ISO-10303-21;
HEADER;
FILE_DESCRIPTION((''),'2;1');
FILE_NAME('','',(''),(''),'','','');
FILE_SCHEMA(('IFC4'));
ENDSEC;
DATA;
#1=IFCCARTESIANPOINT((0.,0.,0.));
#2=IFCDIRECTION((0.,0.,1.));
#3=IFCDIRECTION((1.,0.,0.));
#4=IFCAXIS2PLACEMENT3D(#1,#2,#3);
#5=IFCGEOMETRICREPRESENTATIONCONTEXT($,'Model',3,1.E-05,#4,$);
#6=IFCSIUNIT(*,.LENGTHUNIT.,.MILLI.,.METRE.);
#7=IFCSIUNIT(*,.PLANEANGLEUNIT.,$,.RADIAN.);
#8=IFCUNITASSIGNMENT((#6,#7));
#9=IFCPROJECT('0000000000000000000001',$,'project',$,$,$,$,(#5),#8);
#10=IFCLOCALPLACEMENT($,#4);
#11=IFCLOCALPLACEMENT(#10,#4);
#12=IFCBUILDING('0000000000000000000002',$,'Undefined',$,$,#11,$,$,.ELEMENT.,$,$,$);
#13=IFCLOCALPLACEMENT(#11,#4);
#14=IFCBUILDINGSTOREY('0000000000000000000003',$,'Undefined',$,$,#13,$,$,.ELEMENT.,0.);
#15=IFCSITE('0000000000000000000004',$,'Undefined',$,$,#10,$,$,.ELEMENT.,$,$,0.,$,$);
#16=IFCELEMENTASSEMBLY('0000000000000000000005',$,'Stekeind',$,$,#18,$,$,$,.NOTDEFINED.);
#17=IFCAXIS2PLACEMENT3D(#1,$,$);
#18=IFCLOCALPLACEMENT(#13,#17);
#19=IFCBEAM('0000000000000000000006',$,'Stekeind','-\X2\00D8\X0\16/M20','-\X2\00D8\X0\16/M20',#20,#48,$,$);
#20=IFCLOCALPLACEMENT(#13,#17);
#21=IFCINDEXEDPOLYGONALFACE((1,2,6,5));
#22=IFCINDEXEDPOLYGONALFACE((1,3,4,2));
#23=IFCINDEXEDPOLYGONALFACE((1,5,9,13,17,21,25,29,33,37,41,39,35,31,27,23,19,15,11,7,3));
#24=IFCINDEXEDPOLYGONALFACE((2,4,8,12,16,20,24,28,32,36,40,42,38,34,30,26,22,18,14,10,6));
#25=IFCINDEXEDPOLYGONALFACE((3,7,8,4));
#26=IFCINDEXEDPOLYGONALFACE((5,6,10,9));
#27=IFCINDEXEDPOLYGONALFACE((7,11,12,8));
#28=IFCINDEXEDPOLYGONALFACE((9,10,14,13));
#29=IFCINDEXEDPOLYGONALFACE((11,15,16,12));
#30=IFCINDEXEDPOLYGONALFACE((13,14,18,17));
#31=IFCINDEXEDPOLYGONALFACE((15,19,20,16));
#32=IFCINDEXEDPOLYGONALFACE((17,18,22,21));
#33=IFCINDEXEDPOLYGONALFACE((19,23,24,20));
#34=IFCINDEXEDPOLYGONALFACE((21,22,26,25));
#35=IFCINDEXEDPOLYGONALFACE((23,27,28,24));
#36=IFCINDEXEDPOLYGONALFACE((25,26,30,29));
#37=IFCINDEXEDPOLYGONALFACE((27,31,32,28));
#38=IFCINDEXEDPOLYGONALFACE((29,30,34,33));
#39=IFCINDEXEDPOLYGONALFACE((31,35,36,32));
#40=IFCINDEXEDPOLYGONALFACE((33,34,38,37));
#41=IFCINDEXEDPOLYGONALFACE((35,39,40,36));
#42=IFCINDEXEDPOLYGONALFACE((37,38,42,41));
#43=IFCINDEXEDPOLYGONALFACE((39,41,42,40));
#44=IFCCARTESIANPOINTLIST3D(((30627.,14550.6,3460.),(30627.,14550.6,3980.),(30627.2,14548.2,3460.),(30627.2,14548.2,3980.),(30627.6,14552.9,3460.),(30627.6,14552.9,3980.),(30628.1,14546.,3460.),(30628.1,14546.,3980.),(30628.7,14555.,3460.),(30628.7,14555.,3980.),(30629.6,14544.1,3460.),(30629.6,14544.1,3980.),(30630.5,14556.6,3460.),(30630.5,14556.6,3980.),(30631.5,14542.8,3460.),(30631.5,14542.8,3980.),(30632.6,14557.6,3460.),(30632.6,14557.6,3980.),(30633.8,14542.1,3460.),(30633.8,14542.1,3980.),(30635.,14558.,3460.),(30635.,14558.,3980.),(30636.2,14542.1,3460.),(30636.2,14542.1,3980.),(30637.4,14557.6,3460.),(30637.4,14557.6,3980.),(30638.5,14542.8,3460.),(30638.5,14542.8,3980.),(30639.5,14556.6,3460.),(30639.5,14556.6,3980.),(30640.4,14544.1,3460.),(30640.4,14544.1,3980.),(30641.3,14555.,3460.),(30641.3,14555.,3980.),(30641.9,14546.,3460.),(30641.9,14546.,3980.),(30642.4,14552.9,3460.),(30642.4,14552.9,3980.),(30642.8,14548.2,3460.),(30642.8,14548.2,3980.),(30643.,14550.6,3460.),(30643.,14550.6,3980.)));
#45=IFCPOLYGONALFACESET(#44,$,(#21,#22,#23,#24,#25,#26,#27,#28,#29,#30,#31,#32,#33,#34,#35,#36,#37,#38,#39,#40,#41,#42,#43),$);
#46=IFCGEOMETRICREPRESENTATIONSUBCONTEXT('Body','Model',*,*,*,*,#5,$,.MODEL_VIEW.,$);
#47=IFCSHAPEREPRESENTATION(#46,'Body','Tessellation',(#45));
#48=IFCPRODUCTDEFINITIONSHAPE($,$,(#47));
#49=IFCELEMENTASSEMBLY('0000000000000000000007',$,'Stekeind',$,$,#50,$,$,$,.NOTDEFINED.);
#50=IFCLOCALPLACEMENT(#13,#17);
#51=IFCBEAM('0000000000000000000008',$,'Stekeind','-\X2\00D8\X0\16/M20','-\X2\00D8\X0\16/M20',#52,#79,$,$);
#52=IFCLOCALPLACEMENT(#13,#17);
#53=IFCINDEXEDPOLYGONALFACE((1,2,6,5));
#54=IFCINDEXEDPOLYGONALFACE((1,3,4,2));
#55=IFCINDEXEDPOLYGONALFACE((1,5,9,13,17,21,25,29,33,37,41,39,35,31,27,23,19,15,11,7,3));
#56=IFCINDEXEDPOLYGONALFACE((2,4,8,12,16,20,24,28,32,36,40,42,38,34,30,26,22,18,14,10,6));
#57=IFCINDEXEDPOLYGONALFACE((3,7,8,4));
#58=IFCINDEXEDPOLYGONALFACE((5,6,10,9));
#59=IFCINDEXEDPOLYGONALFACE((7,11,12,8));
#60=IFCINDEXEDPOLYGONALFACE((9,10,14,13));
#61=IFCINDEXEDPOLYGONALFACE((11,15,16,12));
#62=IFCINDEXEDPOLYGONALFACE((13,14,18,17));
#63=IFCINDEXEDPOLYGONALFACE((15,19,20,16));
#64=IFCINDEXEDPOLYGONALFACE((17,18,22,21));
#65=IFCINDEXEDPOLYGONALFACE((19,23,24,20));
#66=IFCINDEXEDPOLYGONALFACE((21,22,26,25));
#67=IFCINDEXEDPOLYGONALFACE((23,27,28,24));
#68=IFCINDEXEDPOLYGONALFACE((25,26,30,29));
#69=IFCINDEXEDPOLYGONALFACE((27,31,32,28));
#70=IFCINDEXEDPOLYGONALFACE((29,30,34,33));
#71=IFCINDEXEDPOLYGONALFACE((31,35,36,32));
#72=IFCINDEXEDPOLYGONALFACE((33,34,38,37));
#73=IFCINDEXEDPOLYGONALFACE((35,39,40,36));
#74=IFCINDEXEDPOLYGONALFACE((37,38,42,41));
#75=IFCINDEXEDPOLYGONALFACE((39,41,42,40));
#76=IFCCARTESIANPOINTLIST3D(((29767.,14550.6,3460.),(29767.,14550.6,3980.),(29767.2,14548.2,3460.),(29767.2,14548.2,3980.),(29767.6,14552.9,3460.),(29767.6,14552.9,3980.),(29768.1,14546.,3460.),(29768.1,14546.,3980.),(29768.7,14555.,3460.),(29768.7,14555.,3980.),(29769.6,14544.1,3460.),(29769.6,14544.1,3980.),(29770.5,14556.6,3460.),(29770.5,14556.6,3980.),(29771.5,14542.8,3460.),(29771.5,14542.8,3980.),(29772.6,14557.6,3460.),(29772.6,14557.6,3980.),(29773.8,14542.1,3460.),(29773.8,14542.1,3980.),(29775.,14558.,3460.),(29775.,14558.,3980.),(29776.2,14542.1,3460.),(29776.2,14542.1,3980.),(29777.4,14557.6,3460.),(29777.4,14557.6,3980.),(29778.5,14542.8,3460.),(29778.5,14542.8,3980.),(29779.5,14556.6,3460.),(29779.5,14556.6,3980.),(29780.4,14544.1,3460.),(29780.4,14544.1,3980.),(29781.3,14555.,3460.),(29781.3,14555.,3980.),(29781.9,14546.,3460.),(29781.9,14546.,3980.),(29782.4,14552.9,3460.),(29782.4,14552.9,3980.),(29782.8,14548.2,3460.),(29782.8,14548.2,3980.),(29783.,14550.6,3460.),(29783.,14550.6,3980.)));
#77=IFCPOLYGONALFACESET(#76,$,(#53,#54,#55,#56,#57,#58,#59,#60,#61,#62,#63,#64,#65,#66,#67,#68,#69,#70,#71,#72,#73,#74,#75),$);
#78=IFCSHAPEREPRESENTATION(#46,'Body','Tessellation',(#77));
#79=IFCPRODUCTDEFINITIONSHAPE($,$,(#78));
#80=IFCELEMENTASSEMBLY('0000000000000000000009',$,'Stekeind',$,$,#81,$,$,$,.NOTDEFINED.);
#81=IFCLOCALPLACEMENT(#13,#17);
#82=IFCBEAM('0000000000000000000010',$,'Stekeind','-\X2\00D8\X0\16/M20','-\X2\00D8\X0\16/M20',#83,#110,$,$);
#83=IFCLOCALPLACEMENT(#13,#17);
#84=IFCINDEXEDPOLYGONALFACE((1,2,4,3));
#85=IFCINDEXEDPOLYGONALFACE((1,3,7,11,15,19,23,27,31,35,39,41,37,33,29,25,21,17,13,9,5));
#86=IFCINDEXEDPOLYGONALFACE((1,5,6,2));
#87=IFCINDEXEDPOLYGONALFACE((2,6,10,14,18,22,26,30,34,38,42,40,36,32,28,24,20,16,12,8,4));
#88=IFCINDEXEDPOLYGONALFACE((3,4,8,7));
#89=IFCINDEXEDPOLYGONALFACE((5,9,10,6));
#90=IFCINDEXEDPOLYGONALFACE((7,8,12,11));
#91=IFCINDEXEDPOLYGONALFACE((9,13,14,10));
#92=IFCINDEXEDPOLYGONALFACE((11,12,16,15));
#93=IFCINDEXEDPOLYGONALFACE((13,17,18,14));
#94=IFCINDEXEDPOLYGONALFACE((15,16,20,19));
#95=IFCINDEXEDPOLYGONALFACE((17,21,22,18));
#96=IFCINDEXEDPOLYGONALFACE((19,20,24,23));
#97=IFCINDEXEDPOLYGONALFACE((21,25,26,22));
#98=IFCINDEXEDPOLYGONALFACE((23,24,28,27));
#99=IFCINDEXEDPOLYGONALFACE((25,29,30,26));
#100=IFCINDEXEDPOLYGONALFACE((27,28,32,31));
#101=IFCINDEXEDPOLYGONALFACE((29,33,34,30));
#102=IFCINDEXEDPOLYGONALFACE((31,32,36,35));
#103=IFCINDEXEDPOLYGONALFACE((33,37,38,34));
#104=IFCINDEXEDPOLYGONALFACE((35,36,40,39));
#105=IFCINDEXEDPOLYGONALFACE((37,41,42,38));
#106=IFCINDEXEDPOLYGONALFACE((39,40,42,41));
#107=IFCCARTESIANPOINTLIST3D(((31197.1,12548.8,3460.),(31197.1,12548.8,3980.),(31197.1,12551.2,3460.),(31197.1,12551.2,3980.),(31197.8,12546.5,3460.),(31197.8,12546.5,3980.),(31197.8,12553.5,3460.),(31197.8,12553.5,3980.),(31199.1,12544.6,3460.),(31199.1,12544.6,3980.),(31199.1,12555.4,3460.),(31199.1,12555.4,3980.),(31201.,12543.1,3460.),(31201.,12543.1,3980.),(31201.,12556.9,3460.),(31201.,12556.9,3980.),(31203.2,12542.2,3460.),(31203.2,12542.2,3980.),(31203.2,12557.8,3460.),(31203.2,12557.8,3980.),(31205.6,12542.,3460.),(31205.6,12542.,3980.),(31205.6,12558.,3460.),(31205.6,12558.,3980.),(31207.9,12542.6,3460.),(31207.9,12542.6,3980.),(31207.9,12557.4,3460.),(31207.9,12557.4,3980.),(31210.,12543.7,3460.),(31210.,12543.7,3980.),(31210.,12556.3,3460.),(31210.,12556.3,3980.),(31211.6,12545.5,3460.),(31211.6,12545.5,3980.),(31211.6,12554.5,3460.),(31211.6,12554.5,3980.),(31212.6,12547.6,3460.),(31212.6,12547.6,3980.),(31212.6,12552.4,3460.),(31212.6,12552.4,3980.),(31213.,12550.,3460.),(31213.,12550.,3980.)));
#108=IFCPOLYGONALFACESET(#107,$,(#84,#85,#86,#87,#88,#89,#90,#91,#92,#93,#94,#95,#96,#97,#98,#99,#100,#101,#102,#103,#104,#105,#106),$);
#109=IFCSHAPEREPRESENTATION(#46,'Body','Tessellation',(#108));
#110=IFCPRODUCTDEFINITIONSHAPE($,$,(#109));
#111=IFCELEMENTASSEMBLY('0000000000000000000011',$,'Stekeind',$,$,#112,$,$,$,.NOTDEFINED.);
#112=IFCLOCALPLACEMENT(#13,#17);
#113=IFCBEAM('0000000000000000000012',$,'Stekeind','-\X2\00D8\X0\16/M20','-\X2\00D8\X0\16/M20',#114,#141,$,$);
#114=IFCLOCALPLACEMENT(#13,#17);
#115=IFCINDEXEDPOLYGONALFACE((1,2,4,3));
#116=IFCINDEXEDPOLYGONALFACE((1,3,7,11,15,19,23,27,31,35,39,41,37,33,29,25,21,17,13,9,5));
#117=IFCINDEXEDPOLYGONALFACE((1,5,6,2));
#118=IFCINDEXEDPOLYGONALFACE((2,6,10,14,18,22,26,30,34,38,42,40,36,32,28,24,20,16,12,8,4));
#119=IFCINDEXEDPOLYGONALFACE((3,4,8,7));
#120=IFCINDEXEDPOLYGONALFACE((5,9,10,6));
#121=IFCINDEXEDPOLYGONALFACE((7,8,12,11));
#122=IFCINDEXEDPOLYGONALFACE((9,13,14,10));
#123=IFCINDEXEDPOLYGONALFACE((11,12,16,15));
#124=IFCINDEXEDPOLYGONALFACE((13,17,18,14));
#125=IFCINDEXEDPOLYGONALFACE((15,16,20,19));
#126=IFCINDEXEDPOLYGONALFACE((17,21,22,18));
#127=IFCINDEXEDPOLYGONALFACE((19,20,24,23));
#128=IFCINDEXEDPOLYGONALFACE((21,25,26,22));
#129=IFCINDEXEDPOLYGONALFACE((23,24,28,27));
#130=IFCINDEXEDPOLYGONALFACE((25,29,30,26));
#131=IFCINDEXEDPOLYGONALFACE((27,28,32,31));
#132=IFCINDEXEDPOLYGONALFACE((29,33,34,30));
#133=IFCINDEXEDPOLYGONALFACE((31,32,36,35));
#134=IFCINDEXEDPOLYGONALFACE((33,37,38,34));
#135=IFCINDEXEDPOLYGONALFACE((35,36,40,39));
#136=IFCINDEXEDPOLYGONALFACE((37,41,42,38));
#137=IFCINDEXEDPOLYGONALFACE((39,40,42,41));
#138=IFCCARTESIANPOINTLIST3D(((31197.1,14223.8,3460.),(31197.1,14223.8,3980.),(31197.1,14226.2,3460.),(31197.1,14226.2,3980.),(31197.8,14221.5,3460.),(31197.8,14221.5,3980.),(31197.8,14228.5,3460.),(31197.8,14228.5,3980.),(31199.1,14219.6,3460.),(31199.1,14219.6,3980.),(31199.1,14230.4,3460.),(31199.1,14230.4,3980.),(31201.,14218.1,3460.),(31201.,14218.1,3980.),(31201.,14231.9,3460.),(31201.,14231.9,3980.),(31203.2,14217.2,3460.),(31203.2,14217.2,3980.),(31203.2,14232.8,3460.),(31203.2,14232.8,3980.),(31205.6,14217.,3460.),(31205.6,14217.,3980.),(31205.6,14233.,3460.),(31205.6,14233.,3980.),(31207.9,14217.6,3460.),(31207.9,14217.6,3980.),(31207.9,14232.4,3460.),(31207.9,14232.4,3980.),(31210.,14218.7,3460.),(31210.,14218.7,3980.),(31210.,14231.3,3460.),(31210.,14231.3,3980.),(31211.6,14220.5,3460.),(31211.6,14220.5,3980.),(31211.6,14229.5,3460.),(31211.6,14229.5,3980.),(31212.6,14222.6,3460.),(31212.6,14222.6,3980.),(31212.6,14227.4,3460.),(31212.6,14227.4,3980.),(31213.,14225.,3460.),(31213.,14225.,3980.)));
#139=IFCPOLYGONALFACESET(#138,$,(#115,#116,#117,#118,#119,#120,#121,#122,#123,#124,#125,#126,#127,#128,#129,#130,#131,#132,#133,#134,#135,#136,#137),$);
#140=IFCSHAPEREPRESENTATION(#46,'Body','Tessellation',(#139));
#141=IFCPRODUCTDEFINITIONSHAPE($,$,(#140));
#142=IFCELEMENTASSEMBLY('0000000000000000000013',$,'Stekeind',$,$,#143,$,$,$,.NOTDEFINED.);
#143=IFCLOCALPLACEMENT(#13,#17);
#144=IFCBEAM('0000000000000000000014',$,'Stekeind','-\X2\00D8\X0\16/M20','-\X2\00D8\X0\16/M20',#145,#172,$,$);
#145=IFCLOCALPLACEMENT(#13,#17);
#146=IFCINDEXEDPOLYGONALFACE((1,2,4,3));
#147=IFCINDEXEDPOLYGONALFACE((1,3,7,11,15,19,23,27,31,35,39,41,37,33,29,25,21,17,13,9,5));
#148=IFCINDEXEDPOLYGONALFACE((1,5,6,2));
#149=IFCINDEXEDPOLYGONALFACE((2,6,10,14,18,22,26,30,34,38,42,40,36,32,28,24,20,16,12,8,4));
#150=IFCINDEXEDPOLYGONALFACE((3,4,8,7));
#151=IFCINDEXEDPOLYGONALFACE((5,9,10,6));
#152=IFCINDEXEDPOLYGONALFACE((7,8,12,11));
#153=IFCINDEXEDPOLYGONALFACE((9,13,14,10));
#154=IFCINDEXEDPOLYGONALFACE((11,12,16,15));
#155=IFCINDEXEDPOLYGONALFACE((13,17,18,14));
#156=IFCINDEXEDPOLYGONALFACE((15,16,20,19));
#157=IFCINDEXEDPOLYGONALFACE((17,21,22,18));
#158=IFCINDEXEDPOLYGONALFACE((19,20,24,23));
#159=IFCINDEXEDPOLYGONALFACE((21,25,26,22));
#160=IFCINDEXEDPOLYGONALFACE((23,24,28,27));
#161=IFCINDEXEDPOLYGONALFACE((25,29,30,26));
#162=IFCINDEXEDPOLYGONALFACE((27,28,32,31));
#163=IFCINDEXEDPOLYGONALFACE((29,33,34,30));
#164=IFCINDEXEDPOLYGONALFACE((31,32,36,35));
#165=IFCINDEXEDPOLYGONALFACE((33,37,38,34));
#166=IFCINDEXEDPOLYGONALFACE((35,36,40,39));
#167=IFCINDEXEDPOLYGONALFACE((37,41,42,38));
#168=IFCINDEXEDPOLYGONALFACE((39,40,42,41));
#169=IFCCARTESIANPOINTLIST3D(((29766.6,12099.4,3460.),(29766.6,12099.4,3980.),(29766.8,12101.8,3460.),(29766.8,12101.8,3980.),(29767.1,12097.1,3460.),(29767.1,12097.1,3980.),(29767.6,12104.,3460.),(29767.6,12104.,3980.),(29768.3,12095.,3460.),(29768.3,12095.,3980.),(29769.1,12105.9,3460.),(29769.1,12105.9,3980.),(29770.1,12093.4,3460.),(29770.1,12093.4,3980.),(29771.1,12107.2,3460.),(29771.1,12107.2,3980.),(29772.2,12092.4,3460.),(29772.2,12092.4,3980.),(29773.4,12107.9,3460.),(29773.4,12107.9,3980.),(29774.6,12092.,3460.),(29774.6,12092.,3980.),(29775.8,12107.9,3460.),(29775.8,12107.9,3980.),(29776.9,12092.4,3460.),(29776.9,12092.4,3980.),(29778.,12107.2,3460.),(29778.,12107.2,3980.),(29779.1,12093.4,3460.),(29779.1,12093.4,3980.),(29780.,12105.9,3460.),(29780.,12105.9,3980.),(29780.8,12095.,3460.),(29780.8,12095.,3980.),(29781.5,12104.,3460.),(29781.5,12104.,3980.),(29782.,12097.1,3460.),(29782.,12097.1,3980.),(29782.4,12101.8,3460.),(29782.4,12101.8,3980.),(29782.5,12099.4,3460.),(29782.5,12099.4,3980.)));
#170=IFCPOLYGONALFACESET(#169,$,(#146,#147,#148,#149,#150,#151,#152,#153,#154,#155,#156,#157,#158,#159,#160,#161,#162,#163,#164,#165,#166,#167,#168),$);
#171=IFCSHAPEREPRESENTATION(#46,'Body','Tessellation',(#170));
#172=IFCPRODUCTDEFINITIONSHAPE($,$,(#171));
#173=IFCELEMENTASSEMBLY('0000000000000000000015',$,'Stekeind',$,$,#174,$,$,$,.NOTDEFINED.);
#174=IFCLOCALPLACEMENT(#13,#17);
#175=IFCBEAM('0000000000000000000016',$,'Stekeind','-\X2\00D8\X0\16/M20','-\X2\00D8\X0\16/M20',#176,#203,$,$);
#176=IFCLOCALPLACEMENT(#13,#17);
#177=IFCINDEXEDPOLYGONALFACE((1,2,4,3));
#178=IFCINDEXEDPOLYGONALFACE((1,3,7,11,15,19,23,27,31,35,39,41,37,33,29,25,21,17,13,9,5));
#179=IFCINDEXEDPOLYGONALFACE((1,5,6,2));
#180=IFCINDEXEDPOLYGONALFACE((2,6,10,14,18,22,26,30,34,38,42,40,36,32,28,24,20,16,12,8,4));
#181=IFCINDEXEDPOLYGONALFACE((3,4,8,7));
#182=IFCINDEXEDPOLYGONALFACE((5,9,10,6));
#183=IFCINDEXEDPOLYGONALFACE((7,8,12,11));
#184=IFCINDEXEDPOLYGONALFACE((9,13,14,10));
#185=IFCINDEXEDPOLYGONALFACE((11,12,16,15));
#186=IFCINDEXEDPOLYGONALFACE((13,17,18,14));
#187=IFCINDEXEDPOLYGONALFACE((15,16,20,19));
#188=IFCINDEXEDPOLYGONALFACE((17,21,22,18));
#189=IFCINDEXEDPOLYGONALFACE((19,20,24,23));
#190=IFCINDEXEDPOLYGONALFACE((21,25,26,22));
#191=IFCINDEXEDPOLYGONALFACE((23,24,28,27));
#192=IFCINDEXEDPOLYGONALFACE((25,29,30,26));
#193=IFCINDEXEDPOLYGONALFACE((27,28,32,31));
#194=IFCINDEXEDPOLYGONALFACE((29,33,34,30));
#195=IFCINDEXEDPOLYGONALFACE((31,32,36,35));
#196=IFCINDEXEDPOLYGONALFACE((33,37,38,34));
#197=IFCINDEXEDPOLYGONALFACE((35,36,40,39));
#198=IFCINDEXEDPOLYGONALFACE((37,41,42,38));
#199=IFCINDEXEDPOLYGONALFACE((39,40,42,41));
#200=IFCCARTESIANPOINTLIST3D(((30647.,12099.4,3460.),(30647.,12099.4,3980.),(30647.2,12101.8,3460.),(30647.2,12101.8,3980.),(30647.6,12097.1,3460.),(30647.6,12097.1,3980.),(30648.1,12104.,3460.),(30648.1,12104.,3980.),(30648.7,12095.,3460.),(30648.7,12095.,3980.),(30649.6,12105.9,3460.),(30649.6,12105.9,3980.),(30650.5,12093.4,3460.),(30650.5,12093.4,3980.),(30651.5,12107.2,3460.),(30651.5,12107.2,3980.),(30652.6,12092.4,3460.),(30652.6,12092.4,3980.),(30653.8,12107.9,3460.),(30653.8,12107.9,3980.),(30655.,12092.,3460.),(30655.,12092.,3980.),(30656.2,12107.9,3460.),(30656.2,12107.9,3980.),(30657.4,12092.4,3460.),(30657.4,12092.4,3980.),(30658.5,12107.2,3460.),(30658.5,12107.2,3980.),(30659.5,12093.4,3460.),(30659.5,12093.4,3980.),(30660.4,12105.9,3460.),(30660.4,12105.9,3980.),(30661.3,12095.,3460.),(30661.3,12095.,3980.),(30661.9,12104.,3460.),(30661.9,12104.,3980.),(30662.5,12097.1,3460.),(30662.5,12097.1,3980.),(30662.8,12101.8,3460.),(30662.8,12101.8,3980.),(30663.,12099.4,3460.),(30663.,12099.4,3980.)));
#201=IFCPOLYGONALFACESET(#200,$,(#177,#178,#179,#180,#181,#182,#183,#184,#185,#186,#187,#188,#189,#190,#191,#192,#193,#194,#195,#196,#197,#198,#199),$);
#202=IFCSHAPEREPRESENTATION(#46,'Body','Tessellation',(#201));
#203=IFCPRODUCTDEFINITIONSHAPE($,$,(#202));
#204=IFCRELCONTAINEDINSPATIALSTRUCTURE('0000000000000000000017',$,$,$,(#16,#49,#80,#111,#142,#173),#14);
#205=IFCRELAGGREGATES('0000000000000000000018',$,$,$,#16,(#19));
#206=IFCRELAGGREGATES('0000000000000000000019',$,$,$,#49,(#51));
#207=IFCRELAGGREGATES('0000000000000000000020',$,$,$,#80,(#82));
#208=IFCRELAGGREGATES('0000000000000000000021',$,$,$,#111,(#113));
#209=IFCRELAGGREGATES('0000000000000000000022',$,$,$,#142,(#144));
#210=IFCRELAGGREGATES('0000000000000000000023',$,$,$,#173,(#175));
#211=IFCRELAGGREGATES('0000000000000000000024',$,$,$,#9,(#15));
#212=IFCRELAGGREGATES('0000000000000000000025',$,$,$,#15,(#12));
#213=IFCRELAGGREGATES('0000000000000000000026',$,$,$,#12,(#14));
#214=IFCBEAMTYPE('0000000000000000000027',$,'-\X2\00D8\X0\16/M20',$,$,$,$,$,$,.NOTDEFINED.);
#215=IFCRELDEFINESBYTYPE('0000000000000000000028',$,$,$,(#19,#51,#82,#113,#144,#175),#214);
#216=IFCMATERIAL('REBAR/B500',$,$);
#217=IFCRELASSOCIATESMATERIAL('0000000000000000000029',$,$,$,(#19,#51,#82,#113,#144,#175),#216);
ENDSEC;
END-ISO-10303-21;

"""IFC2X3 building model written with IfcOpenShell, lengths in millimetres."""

from ifc_helpers import new_model, si_unit, frame, origin_with_axes, origin_2d_with_axis, place, context, subcontext, project, spatial, circle, extrude, material, type_object, element, aggregate, save


model = new_model("IFC2X3")

# Units and contexts
model_context = context("Model", 3, precision=1e-05, world=origin_with_axes())
body_context = subcontext(model_context, "Body", "Model", "MODEL_VIEW")
ifc_project = project(units=[si_unit("LENGTHUNIT", "METRE", prefix="MILLI"), si_unit("PLANEANGLEUNIT", "RADIAN")], contexts=[model_context])

# Site, building, storey
site_placement = place(None, origin_with_axes())
site = spatial("IfcSite", under=ifc_project, at=site_placement, Name="Undefined", CompositionType="ELEMENT", RefElevation=0.0)
building_placement = place(site_placement, origin_with_axes())
building = spatial("IfcBuilding", under=site, at=building_placement, Name="Undefined", CompositionType="ELEMENT")
storey_placement = place(building_placement, origin_with_axes())
storey = spatial("IfcBuildingStorey", under=building, at=storey_placement, Name="Undefined", CompositionType="ELEMENT", Elevation=0.0)

# Element assemblies, beams
ifc_material_1 = material(Name="REBAR/B500")
beam_type_1 = type_object("IfcBeamType", Name="-Ø16/M20", PredefinedType="NOTDEFINED")
assembly_1_placement = place(storey_placement, origin_with_axes())
assembly_1 = element("IfcElementAssembly", 1, at=assembly_1_placement, inside=storey, Name="Stekeind", PredefinedType="NOTDEFINED")
beam_1_placement = place(assembly_1_placement, frame((30635.0, 14550.0, 3980.0), z_axis=(-1.0, 0.0, 0.0), x_axis=(0.0, 0.0, -1.0)))
beam_1 = element("IfcBeam", 2, at=beam_1_placement, type_object=beam_type_1, material=ifc_material_1, Name="Stekeind", Description="-Ø16/M20", ObjectType="-Ø16/M20", context=body_context, shape_type="SweptSolid", body=[
    extrude(circle(Radius=8.0, at=origin_2d_with_axis()), frame((520.0, 0.0, 0.0), z_axis=(-1.0, 0.0, 0.0), x_axis=(0.0, -1.0, 0.0)), (0.0, 0.0, 1.0), 520.0),
])
aggregate(assembly_1, [beam_1])
assembly_2_placement = place(storey_placement, origin_with_axes())
assembly_2 = element("IfcElementAssembly", 3, at=assembly_2_placement, inside=storey, Name="Stekeind", PredefinedType="NOTDEFINED")
beam_2_placement = place(assembly_2_placement, frame((29775.0, 14550.0, 3980.0), z_axis=(-1.0, 0.0, 0.0), x_axis=(0.0, 0.0, -1.0)))
beam_2 = element("IfcBeam", 4, at=beam_2_placement, type_object=beam_type_1, material=ifc_material_1, Name="Stekeind", Description="-Ø16/M20", ObjectType="-Ø16/M20", context=body_context, shape_type="SweptSolid", body=[
    extrude(circle(Radius=8.0, at=origin_2d_with_axis()), frame((520.0, 0.0, 0.0), z_axis=(-1.0, 0.0, 0.0), x_axis=(0.0, -1.0, 0.0)), (0.0, 0.0, 1.0), 520.0),
])
aggregate(assembly_2, [beam_2])
assembly_3_placement = place(storey_placement, origin_with_axes())
assembly_3 = element("IfcElementAssembly", 5, at=assembly_3_placement, inside=storey, Name="Stekeind", PredefinedType="NOTDEFINED")
beam_3_placement = place(assembly_3_placement, frame((31205.0, 12550.0, 3980.0), z_axis=(0.0, 1.0, 0.0), x_axis=(0.0, 0.0, -1.0)))
beam_3 = element("IfcBeam", 6, at=beam_3_placement, type_object=beam_type_1, material=ifc_material_1, Name="Stekeind", Description="-Ø16/M20", ObjectType="-Ø16/M20", context=body_context, shape_type="SweptSolid", body=[
    extrude(circle(Radius=8.0, at=origin_2d_with_axis()), frame((520.0, 0.0, 0.0), z_axis=(-1.0, 0.0, 0.0), x_axis=(0.0, -1.0, 0.0)), (0.0, 0.0, 1.0), 520.0),
])
aggregate(assembly_3, [beam_3])
assembly_4_placement = place(storey_placement, origin_with_axes())
assembly_4 = element("IfcElementAssembly", 7, at=assembly_4_placement, inside=storey, Name="Stekeind", PredefinedType="NOTDEFINED")
beam_4_placement = place(assembly_4_placement, frame((31205.0, 14225.0, 3980.0), z_axis=(0.0, 1.0, 0.0), x_axis=(0.0, 0.0, -1.0)))
beam_4 = element("IfcBeam", 8, at=beam_4_placement, type_object=beam_type_1, material=ifc_material_1, Name="Stekeind", Description="-Ø16/M20", ObjectType="-Ø16/M20", context=body_context, shape_type="SweptSolid", body=[
    extrude(circle(Radius=8.0, at=origin_2d_with_axis()), frame((520.0, 0.0, 0.0), z_axis=(-1.0, 0.0, 0.0), x_axis=(0.0, -1.0, 0.0)), (0.0, 0.0, 1.0), 520.0),
])
aggregate(assembly_4, [beam_4])
assembly_5_placement = place(storey_placement, origin_with_axes())
assembly_5 = element("IfcElementAssembly", 9, at=assembly_5_placement, inside=storey, Name="Stekeind", PredefinedType="NOTDEFINED")
beam_5_placement = place(assembly_5_placement, frame((29774.6, 12100.0, 3980.0), z_axis=(1.0, 0.0, 0.0), x_axis=(0.0, 0.0, -1.0)))
beam_5 = element("IfcBeam", 10, at=beam_5_placement, type_object=beam_type_1, material=ifc_material_1, Name="Stekeind", Description="-Ø16/M20", ObjectType="-Ø16/M20", context=body_context, shape_type="SweptSolid", body=[
    extrude(circle(Radius=8.0, at=origin_2d_with_axis()), frame((520.0, 0.0, 0.0), z_axis=(-1.0, 0.0, 0.0), x_axis=(0.0, -1.0, 0.0)), (0.0, 0.0, 1.0), 520.0),
])
aggregate(assembly_5, [beam_5])
assembly_6_placement = place(storey_placement, origin_with_axes())
assembly_6 = element("IfcElementAssembly", 11, at=assembly_6_placement, inside=storey, Name="Stekeind", PredefinedType="NOTDEFINED")
beam_6_placement = place(assembly_6_placement, frame((30655.0, 12100.0, 3980.0), z_axis=(1.0, 0.0, 0.0), x_axis=(0.0, 0.0, -1.0)))
beam_6 = element("IfcBeam", 12, at=beam_6_placement, type_object=beam_type_1, material=ifc_material_1, Name="Stekeind", Description="-Ø16/M20", ObjectType="-Ø16/M20", context=body_context, shape_type="SweptSolid", body=[
    extrude(circle(Radius=8.0, at=origin_2d_with_axis()), frame((520.0, 0.0, 0.0), z_axis=(-1.0, 0.0, 0.0), x_axis=(0.0, -1.0, 0.0)), (0.0, 0.0, 1.0), 520.0),
])
aggregate(assembly_6, [beam_6])

save(model, "model.ifc")
